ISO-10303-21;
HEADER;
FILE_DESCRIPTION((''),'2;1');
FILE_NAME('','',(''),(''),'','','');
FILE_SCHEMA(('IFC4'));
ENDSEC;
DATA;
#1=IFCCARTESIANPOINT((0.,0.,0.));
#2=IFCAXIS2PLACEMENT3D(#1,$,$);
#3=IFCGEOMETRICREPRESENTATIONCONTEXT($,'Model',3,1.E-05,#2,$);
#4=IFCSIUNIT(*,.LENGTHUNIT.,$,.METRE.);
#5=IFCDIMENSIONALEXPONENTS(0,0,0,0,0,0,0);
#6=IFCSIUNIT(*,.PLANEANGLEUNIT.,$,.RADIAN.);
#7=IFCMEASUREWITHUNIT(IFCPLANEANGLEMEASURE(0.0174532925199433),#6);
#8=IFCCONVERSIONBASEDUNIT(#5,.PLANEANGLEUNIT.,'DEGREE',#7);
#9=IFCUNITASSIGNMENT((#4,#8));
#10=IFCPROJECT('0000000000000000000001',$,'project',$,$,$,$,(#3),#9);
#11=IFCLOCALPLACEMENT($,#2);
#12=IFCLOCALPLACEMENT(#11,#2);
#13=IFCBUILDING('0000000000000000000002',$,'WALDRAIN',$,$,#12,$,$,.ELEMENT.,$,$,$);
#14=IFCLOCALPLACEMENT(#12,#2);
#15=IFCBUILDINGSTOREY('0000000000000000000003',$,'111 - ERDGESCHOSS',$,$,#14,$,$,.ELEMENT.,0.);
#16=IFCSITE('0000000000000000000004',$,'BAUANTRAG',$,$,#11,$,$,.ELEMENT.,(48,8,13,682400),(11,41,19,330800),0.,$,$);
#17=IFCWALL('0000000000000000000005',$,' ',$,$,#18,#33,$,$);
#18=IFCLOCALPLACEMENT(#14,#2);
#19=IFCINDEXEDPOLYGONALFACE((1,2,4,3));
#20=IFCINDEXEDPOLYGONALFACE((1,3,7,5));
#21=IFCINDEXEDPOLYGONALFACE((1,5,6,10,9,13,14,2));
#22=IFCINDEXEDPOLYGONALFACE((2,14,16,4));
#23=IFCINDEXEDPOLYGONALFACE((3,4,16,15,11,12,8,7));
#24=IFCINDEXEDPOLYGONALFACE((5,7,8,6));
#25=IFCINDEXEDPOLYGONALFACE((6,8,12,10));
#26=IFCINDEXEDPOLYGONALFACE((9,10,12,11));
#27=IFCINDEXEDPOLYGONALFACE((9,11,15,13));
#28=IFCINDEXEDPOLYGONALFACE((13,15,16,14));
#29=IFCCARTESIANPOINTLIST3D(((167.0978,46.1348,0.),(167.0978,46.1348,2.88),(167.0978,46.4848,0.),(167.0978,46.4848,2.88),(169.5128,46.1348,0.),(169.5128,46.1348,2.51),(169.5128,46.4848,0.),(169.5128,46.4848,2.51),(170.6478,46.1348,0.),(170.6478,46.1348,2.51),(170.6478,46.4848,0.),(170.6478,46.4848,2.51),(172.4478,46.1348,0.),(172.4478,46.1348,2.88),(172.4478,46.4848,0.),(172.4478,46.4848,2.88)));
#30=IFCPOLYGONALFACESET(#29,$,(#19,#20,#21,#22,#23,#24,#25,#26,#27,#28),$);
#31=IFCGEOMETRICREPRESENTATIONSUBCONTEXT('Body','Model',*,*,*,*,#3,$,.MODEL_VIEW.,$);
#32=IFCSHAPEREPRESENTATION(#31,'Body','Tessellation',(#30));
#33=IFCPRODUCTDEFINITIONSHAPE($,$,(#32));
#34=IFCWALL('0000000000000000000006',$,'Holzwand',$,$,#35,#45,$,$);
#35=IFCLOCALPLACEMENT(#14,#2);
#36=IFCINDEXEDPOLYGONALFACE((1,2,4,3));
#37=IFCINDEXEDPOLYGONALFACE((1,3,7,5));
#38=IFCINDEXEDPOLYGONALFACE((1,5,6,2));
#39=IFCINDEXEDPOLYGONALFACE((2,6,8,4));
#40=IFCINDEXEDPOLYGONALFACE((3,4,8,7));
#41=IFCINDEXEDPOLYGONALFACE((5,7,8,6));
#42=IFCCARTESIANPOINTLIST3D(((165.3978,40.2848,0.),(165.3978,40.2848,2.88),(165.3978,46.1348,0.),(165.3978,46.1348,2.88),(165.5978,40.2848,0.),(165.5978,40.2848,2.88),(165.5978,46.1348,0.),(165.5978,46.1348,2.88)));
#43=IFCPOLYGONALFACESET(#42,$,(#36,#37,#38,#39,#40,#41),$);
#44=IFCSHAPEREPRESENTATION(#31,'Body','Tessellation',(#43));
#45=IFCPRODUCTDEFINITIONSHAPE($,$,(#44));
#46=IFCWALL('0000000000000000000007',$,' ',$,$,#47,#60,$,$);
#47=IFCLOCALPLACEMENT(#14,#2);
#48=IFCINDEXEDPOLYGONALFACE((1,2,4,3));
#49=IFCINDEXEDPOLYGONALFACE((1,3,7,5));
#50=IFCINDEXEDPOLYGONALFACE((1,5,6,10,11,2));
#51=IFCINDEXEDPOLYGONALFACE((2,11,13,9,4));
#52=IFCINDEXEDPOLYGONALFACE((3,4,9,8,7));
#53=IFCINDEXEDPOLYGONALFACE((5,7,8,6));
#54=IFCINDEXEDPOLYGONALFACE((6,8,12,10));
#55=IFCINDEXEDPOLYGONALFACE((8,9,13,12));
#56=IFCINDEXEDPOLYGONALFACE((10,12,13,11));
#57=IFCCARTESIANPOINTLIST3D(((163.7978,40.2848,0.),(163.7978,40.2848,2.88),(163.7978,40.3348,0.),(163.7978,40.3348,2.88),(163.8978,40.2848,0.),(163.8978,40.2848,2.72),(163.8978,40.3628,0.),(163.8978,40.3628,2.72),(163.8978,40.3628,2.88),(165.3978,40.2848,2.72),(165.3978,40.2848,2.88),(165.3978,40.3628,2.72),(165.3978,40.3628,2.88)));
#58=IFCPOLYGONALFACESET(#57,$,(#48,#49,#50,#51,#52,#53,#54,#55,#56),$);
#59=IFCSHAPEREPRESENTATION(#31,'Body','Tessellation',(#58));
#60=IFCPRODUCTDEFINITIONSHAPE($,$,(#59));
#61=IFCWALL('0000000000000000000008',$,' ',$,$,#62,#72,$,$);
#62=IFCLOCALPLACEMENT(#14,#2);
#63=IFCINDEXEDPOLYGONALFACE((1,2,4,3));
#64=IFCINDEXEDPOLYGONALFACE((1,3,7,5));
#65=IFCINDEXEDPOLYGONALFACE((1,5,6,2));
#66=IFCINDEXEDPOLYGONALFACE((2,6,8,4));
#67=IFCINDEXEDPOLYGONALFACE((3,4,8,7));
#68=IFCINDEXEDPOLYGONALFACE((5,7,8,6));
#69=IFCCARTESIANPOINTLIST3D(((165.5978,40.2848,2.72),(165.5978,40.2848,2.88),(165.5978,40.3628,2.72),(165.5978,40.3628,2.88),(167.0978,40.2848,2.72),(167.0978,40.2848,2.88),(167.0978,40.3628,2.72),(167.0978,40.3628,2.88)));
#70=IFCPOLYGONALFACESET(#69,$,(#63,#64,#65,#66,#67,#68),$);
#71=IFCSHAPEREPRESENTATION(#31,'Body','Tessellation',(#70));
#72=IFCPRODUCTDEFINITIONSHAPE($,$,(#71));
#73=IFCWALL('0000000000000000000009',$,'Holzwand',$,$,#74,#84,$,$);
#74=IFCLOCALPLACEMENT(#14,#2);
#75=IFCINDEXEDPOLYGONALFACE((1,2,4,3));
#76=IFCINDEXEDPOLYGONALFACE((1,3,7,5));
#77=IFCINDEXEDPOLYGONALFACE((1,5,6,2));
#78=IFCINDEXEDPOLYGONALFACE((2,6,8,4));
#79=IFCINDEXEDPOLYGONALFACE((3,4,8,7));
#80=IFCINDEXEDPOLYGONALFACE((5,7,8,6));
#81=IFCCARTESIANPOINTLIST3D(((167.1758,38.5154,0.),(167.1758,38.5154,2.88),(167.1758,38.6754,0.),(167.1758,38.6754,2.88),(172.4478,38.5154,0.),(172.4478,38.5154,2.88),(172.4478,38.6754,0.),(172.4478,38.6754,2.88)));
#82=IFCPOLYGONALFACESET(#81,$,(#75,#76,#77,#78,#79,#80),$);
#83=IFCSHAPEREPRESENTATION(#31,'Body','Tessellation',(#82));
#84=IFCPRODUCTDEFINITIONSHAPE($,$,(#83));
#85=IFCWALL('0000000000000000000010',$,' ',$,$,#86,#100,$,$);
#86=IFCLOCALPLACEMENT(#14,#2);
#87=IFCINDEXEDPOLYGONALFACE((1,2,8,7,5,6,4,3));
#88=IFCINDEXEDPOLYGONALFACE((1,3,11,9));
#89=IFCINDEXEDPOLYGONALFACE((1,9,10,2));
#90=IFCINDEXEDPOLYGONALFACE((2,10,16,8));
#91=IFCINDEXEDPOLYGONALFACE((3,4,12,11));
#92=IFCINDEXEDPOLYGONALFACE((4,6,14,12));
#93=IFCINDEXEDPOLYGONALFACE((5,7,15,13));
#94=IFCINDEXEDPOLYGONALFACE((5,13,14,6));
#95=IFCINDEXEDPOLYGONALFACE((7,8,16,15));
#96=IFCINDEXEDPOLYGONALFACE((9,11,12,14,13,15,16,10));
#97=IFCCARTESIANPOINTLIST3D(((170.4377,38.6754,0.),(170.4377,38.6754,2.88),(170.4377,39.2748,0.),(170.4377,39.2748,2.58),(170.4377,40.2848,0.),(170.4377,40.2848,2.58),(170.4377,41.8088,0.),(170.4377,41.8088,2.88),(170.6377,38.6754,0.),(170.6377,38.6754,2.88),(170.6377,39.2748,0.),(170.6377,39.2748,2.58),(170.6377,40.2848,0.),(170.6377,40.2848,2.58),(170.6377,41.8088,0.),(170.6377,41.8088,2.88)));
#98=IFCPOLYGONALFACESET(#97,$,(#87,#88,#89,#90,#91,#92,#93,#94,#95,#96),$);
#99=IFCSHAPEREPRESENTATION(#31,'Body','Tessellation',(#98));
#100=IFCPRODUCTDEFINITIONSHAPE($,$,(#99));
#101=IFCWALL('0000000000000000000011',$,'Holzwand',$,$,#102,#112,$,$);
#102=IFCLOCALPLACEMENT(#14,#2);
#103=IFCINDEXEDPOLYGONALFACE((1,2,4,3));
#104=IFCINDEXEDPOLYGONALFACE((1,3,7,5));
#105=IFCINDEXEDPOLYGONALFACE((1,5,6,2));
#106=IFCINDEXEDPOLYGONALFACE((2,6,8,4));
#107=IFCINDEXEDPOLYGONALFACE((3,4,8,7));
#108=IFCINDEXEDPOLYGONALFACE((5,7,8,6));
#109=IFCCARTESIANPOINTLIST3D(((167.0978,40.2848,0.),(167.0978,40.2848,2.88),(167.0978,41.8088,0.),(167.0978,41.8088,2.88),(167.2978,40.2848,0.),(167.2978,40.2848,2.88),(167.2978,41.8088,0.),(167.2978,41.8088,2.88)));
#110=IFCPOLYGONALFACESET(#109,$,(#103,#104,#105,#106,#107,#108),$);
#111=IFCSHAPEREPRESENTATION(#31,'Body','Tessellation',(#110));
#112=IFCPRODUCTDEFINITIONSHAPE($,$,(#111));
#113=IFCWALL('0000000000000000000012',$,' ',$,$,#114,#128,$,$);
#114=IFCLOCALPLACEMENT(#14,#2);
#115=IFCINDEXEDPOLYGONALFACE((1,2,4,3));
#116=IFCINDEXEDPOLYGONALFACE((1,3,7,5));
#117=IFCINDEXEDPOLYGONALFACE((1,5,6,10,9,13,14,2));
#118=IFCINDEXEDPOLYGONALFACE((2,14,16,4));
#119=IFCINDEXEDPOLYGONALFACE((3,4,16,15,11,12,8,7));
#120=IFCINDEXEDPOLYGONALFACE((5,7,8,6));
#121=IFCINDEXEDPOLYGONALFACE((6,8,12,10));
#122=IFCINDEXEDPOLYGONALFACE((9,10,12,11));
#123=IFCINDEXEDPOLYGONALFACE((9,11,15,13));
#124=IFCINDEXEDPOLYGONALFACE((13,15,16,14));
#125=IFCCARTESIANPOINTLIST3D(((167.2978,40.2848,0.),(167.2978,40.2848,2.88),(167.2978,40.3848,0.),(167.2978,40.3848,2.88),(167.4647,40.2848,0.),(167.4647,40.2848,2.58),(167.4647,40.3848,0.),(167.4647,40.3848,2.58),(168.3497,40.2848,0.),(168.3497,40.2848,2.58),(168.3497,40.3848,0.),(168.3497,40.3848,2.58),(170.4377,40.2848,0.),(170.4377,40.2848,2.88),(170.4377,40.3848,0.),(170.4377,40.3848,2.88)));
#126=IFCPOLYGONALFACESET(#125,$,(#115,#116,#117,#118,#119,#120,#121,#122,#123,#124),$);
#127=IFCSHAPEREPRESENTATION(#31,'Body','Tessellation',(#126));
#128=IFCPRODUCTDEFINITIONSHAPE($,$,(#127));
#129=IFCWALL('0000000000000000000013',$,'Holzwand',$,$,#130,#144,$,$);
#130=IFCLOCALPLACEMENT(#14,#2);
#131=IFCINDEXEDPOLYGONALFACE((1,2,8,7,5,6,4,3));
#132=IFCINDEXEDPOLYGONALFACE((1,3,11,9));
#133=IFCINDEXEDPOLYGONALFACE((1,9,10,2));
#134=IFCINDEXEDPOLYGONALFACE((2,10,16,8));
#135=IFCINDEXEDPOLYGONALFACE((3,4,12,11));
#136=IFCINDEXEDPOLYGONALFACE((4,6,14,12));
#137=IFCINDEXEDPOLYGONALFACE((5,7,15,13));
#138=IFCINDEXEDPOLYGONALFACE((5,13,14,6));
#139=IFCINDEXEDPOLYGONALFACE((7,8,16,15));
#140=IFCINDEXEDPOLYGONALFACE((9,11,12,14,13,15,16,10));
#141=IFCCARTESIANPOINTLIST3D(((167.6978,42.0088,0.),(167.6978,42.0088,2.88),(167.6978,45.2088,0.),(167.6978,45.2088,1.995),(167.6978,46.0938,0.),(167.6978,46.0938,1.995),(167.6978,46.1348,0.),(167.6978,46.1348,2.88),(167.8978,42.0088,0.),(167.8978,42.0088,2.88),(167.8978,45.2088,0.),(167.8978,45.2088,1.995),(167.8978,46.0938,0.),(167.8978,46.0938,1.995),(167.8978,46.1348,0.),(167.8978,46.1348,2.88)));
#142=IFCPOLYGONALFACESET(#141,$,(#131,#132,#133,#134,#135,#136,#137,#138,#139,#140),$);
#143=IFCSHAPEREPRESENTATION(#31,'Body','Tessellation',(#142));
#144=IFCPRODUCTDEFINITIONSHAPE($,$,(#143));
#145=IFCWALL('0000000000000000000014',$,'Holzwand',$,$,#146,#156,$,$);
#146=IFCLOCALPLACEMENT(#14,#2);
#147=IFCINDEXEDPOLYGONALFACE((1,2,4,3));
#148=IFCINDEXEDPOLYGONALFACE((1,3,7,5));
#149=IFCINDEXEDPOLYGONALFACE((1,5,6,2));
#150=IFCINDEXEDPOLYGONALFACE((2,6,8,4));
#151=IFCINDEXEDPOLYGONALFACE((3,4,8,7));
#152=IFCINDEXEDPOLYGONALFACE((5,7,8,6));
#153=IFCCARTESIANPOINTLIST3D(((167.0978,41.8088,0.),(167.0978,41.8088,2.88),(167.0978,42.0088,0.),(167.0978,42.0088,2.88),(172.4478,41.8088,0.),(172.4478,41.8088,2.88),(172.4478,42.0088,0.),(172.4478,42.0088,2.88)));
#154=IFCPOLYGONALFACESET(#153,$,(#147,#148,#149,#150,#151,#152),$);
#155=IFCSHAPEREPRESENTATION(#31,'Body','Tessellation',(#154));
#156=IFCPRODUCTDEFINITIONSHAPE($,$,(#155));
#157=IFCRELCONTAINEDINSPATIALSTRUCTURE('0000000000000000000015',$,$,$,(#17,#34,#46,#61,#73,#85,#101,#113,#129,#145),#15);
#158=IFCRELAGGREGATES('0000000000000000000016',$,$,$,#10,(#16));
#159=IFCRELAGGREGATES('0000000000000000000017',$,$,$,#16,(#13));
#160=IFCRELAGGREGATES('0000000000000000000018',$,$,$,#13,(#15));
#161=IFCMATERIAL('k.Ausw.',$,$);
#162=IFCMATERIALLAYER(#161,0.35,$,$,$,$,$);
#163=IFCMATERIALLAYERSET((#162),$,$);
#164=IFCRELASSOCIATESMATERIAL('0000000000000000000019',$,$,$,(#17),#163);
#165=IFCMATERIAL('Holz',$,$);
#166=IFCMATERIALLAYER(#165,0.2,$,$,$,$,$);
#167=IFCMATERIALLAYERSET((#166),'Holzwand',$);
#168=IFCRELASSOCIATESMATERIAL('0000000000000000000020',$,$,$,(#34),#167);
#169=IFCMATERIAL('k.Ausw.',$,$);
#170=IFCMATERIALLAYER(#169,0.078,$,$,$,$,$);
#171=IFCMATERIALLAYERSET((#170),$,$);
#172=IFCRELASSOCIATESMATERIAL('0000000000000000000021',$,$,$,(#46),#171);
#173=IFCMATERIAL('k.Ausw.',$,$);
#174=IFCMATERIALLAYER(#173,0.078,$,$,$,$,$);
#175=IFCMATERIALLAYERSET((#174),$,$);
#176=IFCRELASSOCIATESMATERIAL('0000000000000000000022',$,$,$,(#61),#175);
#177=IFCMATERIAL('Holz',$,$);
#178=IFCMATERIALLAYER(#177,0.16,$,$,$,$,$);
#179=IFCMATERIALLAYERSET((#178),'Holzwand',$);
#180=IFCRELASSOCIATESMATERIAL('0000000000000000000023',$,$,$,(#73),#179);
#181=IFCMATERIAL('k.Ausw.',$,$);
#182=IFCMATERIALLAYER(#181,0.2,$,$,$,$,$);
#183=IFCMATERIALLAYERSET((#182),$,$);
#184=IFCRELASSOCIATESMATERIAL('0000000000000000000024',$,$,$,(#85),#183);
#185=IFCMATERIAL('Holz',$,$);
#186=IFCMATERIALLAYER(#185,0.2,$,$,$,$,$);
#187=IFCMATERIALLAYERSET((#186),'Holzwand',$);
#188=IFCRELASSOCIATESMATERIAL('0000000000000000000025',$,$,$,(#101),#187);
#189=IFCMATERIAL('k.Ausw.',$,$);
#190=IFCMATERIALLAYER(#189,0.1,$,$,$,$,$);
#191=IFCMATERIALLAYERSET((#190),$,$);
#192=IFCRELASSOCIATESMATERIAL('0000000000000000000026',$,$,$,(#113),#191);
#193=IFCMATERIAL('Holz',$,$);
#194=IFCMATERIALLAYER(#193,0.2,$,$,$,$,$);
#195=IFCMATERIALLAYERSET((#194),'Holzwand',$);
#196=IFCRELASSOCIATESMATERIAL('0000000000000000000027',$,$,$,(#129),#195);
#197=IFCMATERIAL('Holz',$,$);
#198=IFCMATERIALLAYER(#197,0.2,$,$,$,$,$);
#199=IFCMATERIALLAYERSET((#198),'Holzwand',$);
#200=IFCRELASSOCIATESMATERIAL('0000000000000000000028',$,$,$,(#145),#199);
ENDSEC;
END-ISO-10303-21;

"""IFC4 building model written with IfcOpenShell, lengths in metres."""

from ifc_helpers import new_model, entity, si_unit, converted_unit, frame, frame_2d, origin, origin_with_axes, place, context, subcontext, project, spatial, polyline, rectangle, outline, extrude, material, layer, layer_set, layer_usage, element, save


model = new_model("IFC4")

# Units and contexts
model_context = context("Model", 3, precision=1e-05, world=origin())
body_context = subcontext(model_context, "Body", "Model", "MODEL_VIEW")
ifc_project = project(units=[si_unit("LENGTHUNIT", "METRE"), converted_unit("PLANEANGLEUNIT", "DEGREE", entity("IfcPlaneAngleMeasure", 0.0174532925199433), si_unit("PLANEANGLEUNIT", "RADIAN"), dimensions=[0, 0, 0, 0, 0, 0, 0])], contexts=[model_context])

# Site, building, storey
site_placement = place(None, origin())
site = spatial("IfcSite", under=ifc_project, at=site_placement, Name="BAUANTRAG", CompositionType="ELEMENT", RefLatitude=(48, 8, 13, 682400), RefLongitude=(11, 41, 19, 330800), RefElevation=0.0)
building_placement = place(site_placement, origin())
building = spatial("IfcBuilding", under=site, at=building_placement, Name="WALDRAIN", CompositionType="ELEMENT")
storey_placement = place(building_placement, origin())
storey = spatial("IfcBuildingStorey", under=building, at=storey_placement, Name="111 - ERDGESCHOSS", CompositionType="ELEMENT", Elevation=0.0)

# Wall, opening
ifc_material_1 = material(Name="k.Ausw.")
ifc_layer_1 = layer(ifc_material_1, 0.35)
ifc_layer_set_1 = layer_set([ifc_layer_1])
ifc_layer_usage_1 = layer_usage(ifc_layer_set_1, "AXIS2", "POSITIVE", 0.0)
wall_1_placement = place(storey_placement, frame((172.4478, 46.4848, 0.0), z_axis=(0.0, 0.0, 1.0), x_axis=(-1.0, 0.0, 0.0)))
wall_1 = element("IfcWall", 1, at=wall_1_placement, inside=storey, material=ifc_layer_usage_1, Name=" ", context=body_context, shape_type="SweptSolid", body=[
    extrude(rectangle(XDim=5.35, YDim=0.35, at=frame_2d((2.675, 0.175), x_axis=(1.0, 0.0))), origin_with_axes(), (0.0, 0.0, 1.0), 2.88),
])
opening_1_placement = place(wall_1_placement, frame((2.935, 0.35, 0.0), z_axis=(0.0, -1.0, 0.0), x_axis=(0.0, 0.0, 1.0)))
element("IfcOpeningElement", 2, at=opening_1_placement, cuts=wall_1, ObjectType="Opening", context=body_context, shape_type="SweptSolid", body=[
    extrude(outline(polyline([(0.0, 1.135), (2.51, 1.135), (2.51, 0.0), (0.0, 0.0), (0.0, 1.135)])), origin_with_axes(), (0.0, 0.0, 1.0), 0.35),
])

# Wall
ifc_material_2 = material(Name="Holz")
ifc_layer_2 = layer(ifc_material_2, 0.2)
ifc_layer_set_2 = layer_set([ifc_layer_2], Name="Holzwand")
ifc_layer_usage_2 = layer_usage(ifc_layer_set_2, "AXIS2", "POSITIVE", 0.0)
wall_2_placement = place(storey_placement, frame((165.3978, 46.1348, 0.0), z_axis=(0.0, 0.0, 1.0), x_axis=(0.0, -1.0, 0.0)))
element("IfcWall", 3, at=wall_2_placement, inside=storey, material=ifc_layer_usage_2, Name="Holzwand", context=body_context, shape_type="SweptSolid", body=[
    extrude(rectangle(XDim=5.85, YDim=0.2, at=frame_2d((2.925, 0.1), x_axis=(1.0, 0.0))), origin_with_axes(), (0.0, 0.0, 1.0), 2.88),
])

# Walls, openings
ifc_material_3 = material(Name="k.Ausw.")
ifc_layer_3 = layer(ifc_material_3, 0.078)
ifc_layer_set_3 = layer_set([ifc_layer_3])
ifc_layer_usage_3 = layer_usage(ifc_layer_set_3, "AXIS2", "POSITIVE", 0.0)
wall_3_placement = place(storey_placement, frame((165.3978, 40.3628, 0.0), z_axis=(0.0, 0.0, 1.0), x_axis=(-1.0, 0.0, 0.0)))
wall_3 = element("IfcWall", 4, at=wall_3_placement, inside=storey, material=ifc_layer_usage_3, Name=" ", context=body_context, shape_type="SweptSolid", body=[
    extrude(outline(polyline([(-1.6, -0.078), (-0.1, -0.078), (0.0, -0.05), (0.0, 0.0), (-1.6, 0.0), (-1.6, -0.078)])), frame((1.6, 0.078, 0.0), z_axis=(0.0, 0.0, 1.0), x_axis=(1.0, 0.0, 0.0)), (0.0, 0.0, 1.0), 2.88),
])
opening_2_placement = place(wall_3_placement, frame((1.5, 0.078, 0.0), z_axis=(0.0, -1.0, 0.0), x_axis=(0.0, 0.0, 1.0)))
element("IfcOpeningElement", 5, at=opening_2_placement, cuts=wall_3, ObjectType="Opening", context=body_context, shape_type="SweptSolid", body=[
    extrude(outline(polyline([(0.0, 1.5), (2.72, 1.5), (2.72, 0.0), (0.0, 0.0), (0.0, 1.5)])), origin_with_axes(), (0.0, 0.0, 1.0), 0.078),
])
ifc_material_4 = material(Name="k.Ausw.")
ifc_layer_4 = layer(ifc_material_4, 0.078)
ifc_layer_set_4 = layer_set([ifc_layer_4])
ifc_layer_usage_4 = layer_usage(ifc_layer_set_4, "AXIS2", "POSITIVE", 0.0)
wall_4_placement = place(storey_placement, frame((165.5978, 40.2848, 0.0)))
wall_4 = element("IfcWall", 6, at=wall_4_placement, inside=storey, material=ifc_layer_usage_4, Name=" ", context=body_context, shape_type="SweptSolid", body=[
    extrude(rectangle(XDim=1.5, YDim=0.078, at=frame_2d((0.75, 0.039), x_axis=(1.0, 0.0))), origin_with_axes(), (0.0, 0.0, 1.0), 2.88),
])
opening_3_placement = place(wall_4_placement, frame((0.0, 0.0, 0.0), z_axis=(0.0, 1.0, 0.0), x_axis=(0.0, 0.0, 1.0)))
element("IfcOpeningElement", 7, at=opening_3_placement, cuts=wall_4, ObjectType="Opening", context=body_context, shape_type="SweptSolid", body=[
    extrude(outline(polyline([(0.0, 1.5), (2.72, 1.5), (2.72, 0.0), (0.0, 0.0), (0.0, 1.5)])), origin_with_axes(), (0.0, 0.0, 1.0), 0.078),
])

# Wall
ifc_material_5 = material(Name="Holz")
ifc_layer_5 = layer(ifc_material_5, 0.16)
ifc_layer_set_5 = layer_set([ifc_layer_5], Name="Holzwand")
ifc_layer_usage_5 = layer_usage(ifc_layer_set_5, "AXIS2", "POSITIVE", 0.0)
wall_5_placement = place(storey_placement, frame((172.4478, 38.6754, 0.0), z_axis=(0.0, 0.0, 1.0), x_axis=(-1.0, 0.0, 0.0)))
element("IfcWall", 8, at=wall_5_placement, inside=storey, material=ifc_layer_usage_5, Name="Holzwand", context=body_context, shape_type="SweptSolid", body=[
    extrude(rectangle(XDim=5.272, YDim=0.16, at=frame_2d((2.636, 0.08), x_axis=(1.0, 0.0))), origin_with_axes(), (0.0, 0.0, 1.0), 2.88),
])

# Wall, opening
ifc_material_6 = material(Name="k.Ausw.")
ifc_layer_6 = layer(ifc_material_6, 0.2)
ifc_layer_set_6 = layer_set([ifc_layer_6])
ifc_layer_usage_6 = layer_usage(ifc_layer_set_6, "AXIS2", "POSITIVE", 0.0)
wall_6_placement = place(storey_placement, frame((170.4377, 41.8088, 0.0), z_axis=(0.0, 0.0, 1.0), x_axis=(0.0, -1.0, 0.0)))
wall_6 = element("IfcWall", 9, at=wall_6_placement, inside=storey, material=ifc_layer_usage_6, Name=" ", context=body_context, shape_type="SweptSolid", body=[
    extrude(rectangle(XDim=3.1334, YDim=0.2, at=frame_2d((1.5667, 0.1), x_axis=(1.0, 0.0))), origin_with_axes(), (0.0, 0.0, 1.0), 2.88),
])
opening_4_placement = place(wall_6_placement, frame((2.534, 0.2, -0.14), z_axis=(0.0, -1.0, 0.0), x_axis=(0.0, 0.0, 1.0)))
element("IfcOpeningElement", 10, at=opening_4_placement, cuts=wall_6, ObjectType="Opening", context=body_context, shape_type="SweptSolid", body=[
    extrude(outline(polyline([(0.0, 1.01), (2.72, 1.01), (2.72, 0.0), (0.0, 0.0), (0.0, 1.01)])), origin_with_axes(), (0.0, 0.0, 1.0), 0.2),
])

# Wall
ifc_material_7 = material(Name="Holz")
ifc_layer_7 = layer(ifc_material_7, 0.2)
ifc_layer_set_7 = layer_set([ifc_layer_7], Name="Holzwand")
ifc_layer_usage_7 = layer_usage(ifc_layer_set_7, "AXIS2", "POSITIVE", 0.0)
wall_7_placement = place(storey_placement, frame((167.0978, 41.8088, 0.0), z_axis=(0.0, 0.0, 1.0), x_axis=(0.0, -1.0, 0.0)))
element("IfcWall", 11, at=wall_7_placement, inside=storey, material=ifc_layer_usage_7, Name="Holzwand", context=body_context, shape_type="SweptSolid", body=[
    extrude(rectangle(XDim=1.524, YDim=0.2, at=frame_2d((0.762, 0.1), x_axis=(1.0, 0.0))), origin_with_axes(), (0.0, 0.0, 1.0), 2.88),
])

# Walls, openings
ifc_material_8 = material(Name="k.Ausw.")
ifc_layer_8 = layer(ifc_material_8, 0.1)
ifc_layer_set_8 = layer_set([ifc_layer_8])
ifc_layer_usage_8 = layer_usage(ifc_layer_set_8, "AXIS2", "POSITIVE", 0.0)
wall_8_placement = place(storey_placement, frame((170.4377, 40.3848, 0.0), z_axis=(0.0, 0.0, 1.0), x_axis=(-1.0, 0.0, 0.0)))
wall_8 = element("IfcWall", 12, at=wall_8_placement, inside=storey, material=ifc_layer_usage_8, Name=" ", context=body_context, shape_type="SweptSolid", body=[
    extrude(rectangle(XDim=3.1399, YDim=0.1, at=frame_2d((1.57, 0.05), x_axis=(1.0, 0.0))), origin_with_axes(), (0.0, 0.0, 1.0), 2.88),
])
opening_5_placement = place(wall_8_placement, frame((2.973, 0.1, -0.14), z_axis=(0.0, -1.0, 0.0), x_axis=(0.0, 0.0, 1.0)))
element("IfcOpeningElement", 13, at=opening_5_placement, cuts=wall_8, ObjectType="Opening", context=body_context, shape_type="SweptSolid", body=[
    extrude(outline(polyline([(0.0, 0.885), (2.72, 0.885), (2.72, 0.0), (0.0, 0.0), (0.0, 0.885)])), origin_with_axes(), (0.0, 0.0, 1.0), 0.1),
])
ifc_material_9 = material(Name="Holz")
ifc_layer_9 = layer(ifc_material_9, 0.2)
ifc_layer_set_9 = layer_set([ifc_layer_9], Name="Holzwand")
ifc_layer_usage_9 = layer_usage(ifc_layer_set_9, "AXIS2", "POSITIVE", 0.0)
wall_9_placement = place(storey_placement, frame((167.6978, 46.1348, 0.0), z_axis=(0.0, 0.0, 1.0), x_axis=(0.0, -1.0, 0.0)))
wall_9 = element("IfcWall", 14, at=wall_9_placement, inside=storey, material=ifc_layer_usage_9, Name="Holzwand", context=body_context, shape_type="SweptSolid", body=[
    extrude(rectangle(XDim=4.126, YDim=0.2, at=frame_2d((2.063, 0.1), x_axis=(1.0, 0.0))), origin_with_axes(), (0.0, 0.0, 1.0), 2.88),
])
opening_6_placement = place(wall_9_placement, frame((0.926, 0.2, -0.14), z_axis=(0.0, -1.0, 0.0), x_axis=(0.0, 0.0, 1.0)))
element("IfcOpeningElement", 15, at=opening_6_placement, cuts=wall_9, ObjectType="Opening", context=body_context, shape_type="SweptSolid", body=[
    extrude(outline(polyline([(0.0, 0.885), (2.135, 0.885), (2.135, 0.0), (0.0, 0.0), (0.0, 0.885)])), origin_with_axes(), (0.0, 0.0, 1.0), 0.2),
])

# Wall
ifc_material_10 = material(Name="Holz")
ifc_layer_10 = layer(ifc_material_10, 0.2)
ifc_layer_set_10 = layer_set([ifc_layer_10], Name="Holzwand")
ifc_layer_usage_10 = layer_usage(ifc_layer_set_10, "AXIS2", "POSITIVE", 0.0)
wall_10_placement = place(storey_placement, frame((172.4478, 42.0088, 0.0), z_axis=(0.0, 0.0, 1.0), x_axis=(-1.0, 0.0, 0.0)))
element("IfcWall", 16, at=wall_10_placement, inside=storey, material=ifc_layer_usage_10, Name="Holzwand", context=body_context, shape_type="SweptSolid", body=[
    extrude(rectangle(XDim=5.35, YDim=0.2, at=frame_2d((2.675, 0.1), x_axis=(1.0, 0.0))), origin_with_axes(), (0.0, 0.0, 1.0), 2.88),
])

save(model, "model.ifc")
